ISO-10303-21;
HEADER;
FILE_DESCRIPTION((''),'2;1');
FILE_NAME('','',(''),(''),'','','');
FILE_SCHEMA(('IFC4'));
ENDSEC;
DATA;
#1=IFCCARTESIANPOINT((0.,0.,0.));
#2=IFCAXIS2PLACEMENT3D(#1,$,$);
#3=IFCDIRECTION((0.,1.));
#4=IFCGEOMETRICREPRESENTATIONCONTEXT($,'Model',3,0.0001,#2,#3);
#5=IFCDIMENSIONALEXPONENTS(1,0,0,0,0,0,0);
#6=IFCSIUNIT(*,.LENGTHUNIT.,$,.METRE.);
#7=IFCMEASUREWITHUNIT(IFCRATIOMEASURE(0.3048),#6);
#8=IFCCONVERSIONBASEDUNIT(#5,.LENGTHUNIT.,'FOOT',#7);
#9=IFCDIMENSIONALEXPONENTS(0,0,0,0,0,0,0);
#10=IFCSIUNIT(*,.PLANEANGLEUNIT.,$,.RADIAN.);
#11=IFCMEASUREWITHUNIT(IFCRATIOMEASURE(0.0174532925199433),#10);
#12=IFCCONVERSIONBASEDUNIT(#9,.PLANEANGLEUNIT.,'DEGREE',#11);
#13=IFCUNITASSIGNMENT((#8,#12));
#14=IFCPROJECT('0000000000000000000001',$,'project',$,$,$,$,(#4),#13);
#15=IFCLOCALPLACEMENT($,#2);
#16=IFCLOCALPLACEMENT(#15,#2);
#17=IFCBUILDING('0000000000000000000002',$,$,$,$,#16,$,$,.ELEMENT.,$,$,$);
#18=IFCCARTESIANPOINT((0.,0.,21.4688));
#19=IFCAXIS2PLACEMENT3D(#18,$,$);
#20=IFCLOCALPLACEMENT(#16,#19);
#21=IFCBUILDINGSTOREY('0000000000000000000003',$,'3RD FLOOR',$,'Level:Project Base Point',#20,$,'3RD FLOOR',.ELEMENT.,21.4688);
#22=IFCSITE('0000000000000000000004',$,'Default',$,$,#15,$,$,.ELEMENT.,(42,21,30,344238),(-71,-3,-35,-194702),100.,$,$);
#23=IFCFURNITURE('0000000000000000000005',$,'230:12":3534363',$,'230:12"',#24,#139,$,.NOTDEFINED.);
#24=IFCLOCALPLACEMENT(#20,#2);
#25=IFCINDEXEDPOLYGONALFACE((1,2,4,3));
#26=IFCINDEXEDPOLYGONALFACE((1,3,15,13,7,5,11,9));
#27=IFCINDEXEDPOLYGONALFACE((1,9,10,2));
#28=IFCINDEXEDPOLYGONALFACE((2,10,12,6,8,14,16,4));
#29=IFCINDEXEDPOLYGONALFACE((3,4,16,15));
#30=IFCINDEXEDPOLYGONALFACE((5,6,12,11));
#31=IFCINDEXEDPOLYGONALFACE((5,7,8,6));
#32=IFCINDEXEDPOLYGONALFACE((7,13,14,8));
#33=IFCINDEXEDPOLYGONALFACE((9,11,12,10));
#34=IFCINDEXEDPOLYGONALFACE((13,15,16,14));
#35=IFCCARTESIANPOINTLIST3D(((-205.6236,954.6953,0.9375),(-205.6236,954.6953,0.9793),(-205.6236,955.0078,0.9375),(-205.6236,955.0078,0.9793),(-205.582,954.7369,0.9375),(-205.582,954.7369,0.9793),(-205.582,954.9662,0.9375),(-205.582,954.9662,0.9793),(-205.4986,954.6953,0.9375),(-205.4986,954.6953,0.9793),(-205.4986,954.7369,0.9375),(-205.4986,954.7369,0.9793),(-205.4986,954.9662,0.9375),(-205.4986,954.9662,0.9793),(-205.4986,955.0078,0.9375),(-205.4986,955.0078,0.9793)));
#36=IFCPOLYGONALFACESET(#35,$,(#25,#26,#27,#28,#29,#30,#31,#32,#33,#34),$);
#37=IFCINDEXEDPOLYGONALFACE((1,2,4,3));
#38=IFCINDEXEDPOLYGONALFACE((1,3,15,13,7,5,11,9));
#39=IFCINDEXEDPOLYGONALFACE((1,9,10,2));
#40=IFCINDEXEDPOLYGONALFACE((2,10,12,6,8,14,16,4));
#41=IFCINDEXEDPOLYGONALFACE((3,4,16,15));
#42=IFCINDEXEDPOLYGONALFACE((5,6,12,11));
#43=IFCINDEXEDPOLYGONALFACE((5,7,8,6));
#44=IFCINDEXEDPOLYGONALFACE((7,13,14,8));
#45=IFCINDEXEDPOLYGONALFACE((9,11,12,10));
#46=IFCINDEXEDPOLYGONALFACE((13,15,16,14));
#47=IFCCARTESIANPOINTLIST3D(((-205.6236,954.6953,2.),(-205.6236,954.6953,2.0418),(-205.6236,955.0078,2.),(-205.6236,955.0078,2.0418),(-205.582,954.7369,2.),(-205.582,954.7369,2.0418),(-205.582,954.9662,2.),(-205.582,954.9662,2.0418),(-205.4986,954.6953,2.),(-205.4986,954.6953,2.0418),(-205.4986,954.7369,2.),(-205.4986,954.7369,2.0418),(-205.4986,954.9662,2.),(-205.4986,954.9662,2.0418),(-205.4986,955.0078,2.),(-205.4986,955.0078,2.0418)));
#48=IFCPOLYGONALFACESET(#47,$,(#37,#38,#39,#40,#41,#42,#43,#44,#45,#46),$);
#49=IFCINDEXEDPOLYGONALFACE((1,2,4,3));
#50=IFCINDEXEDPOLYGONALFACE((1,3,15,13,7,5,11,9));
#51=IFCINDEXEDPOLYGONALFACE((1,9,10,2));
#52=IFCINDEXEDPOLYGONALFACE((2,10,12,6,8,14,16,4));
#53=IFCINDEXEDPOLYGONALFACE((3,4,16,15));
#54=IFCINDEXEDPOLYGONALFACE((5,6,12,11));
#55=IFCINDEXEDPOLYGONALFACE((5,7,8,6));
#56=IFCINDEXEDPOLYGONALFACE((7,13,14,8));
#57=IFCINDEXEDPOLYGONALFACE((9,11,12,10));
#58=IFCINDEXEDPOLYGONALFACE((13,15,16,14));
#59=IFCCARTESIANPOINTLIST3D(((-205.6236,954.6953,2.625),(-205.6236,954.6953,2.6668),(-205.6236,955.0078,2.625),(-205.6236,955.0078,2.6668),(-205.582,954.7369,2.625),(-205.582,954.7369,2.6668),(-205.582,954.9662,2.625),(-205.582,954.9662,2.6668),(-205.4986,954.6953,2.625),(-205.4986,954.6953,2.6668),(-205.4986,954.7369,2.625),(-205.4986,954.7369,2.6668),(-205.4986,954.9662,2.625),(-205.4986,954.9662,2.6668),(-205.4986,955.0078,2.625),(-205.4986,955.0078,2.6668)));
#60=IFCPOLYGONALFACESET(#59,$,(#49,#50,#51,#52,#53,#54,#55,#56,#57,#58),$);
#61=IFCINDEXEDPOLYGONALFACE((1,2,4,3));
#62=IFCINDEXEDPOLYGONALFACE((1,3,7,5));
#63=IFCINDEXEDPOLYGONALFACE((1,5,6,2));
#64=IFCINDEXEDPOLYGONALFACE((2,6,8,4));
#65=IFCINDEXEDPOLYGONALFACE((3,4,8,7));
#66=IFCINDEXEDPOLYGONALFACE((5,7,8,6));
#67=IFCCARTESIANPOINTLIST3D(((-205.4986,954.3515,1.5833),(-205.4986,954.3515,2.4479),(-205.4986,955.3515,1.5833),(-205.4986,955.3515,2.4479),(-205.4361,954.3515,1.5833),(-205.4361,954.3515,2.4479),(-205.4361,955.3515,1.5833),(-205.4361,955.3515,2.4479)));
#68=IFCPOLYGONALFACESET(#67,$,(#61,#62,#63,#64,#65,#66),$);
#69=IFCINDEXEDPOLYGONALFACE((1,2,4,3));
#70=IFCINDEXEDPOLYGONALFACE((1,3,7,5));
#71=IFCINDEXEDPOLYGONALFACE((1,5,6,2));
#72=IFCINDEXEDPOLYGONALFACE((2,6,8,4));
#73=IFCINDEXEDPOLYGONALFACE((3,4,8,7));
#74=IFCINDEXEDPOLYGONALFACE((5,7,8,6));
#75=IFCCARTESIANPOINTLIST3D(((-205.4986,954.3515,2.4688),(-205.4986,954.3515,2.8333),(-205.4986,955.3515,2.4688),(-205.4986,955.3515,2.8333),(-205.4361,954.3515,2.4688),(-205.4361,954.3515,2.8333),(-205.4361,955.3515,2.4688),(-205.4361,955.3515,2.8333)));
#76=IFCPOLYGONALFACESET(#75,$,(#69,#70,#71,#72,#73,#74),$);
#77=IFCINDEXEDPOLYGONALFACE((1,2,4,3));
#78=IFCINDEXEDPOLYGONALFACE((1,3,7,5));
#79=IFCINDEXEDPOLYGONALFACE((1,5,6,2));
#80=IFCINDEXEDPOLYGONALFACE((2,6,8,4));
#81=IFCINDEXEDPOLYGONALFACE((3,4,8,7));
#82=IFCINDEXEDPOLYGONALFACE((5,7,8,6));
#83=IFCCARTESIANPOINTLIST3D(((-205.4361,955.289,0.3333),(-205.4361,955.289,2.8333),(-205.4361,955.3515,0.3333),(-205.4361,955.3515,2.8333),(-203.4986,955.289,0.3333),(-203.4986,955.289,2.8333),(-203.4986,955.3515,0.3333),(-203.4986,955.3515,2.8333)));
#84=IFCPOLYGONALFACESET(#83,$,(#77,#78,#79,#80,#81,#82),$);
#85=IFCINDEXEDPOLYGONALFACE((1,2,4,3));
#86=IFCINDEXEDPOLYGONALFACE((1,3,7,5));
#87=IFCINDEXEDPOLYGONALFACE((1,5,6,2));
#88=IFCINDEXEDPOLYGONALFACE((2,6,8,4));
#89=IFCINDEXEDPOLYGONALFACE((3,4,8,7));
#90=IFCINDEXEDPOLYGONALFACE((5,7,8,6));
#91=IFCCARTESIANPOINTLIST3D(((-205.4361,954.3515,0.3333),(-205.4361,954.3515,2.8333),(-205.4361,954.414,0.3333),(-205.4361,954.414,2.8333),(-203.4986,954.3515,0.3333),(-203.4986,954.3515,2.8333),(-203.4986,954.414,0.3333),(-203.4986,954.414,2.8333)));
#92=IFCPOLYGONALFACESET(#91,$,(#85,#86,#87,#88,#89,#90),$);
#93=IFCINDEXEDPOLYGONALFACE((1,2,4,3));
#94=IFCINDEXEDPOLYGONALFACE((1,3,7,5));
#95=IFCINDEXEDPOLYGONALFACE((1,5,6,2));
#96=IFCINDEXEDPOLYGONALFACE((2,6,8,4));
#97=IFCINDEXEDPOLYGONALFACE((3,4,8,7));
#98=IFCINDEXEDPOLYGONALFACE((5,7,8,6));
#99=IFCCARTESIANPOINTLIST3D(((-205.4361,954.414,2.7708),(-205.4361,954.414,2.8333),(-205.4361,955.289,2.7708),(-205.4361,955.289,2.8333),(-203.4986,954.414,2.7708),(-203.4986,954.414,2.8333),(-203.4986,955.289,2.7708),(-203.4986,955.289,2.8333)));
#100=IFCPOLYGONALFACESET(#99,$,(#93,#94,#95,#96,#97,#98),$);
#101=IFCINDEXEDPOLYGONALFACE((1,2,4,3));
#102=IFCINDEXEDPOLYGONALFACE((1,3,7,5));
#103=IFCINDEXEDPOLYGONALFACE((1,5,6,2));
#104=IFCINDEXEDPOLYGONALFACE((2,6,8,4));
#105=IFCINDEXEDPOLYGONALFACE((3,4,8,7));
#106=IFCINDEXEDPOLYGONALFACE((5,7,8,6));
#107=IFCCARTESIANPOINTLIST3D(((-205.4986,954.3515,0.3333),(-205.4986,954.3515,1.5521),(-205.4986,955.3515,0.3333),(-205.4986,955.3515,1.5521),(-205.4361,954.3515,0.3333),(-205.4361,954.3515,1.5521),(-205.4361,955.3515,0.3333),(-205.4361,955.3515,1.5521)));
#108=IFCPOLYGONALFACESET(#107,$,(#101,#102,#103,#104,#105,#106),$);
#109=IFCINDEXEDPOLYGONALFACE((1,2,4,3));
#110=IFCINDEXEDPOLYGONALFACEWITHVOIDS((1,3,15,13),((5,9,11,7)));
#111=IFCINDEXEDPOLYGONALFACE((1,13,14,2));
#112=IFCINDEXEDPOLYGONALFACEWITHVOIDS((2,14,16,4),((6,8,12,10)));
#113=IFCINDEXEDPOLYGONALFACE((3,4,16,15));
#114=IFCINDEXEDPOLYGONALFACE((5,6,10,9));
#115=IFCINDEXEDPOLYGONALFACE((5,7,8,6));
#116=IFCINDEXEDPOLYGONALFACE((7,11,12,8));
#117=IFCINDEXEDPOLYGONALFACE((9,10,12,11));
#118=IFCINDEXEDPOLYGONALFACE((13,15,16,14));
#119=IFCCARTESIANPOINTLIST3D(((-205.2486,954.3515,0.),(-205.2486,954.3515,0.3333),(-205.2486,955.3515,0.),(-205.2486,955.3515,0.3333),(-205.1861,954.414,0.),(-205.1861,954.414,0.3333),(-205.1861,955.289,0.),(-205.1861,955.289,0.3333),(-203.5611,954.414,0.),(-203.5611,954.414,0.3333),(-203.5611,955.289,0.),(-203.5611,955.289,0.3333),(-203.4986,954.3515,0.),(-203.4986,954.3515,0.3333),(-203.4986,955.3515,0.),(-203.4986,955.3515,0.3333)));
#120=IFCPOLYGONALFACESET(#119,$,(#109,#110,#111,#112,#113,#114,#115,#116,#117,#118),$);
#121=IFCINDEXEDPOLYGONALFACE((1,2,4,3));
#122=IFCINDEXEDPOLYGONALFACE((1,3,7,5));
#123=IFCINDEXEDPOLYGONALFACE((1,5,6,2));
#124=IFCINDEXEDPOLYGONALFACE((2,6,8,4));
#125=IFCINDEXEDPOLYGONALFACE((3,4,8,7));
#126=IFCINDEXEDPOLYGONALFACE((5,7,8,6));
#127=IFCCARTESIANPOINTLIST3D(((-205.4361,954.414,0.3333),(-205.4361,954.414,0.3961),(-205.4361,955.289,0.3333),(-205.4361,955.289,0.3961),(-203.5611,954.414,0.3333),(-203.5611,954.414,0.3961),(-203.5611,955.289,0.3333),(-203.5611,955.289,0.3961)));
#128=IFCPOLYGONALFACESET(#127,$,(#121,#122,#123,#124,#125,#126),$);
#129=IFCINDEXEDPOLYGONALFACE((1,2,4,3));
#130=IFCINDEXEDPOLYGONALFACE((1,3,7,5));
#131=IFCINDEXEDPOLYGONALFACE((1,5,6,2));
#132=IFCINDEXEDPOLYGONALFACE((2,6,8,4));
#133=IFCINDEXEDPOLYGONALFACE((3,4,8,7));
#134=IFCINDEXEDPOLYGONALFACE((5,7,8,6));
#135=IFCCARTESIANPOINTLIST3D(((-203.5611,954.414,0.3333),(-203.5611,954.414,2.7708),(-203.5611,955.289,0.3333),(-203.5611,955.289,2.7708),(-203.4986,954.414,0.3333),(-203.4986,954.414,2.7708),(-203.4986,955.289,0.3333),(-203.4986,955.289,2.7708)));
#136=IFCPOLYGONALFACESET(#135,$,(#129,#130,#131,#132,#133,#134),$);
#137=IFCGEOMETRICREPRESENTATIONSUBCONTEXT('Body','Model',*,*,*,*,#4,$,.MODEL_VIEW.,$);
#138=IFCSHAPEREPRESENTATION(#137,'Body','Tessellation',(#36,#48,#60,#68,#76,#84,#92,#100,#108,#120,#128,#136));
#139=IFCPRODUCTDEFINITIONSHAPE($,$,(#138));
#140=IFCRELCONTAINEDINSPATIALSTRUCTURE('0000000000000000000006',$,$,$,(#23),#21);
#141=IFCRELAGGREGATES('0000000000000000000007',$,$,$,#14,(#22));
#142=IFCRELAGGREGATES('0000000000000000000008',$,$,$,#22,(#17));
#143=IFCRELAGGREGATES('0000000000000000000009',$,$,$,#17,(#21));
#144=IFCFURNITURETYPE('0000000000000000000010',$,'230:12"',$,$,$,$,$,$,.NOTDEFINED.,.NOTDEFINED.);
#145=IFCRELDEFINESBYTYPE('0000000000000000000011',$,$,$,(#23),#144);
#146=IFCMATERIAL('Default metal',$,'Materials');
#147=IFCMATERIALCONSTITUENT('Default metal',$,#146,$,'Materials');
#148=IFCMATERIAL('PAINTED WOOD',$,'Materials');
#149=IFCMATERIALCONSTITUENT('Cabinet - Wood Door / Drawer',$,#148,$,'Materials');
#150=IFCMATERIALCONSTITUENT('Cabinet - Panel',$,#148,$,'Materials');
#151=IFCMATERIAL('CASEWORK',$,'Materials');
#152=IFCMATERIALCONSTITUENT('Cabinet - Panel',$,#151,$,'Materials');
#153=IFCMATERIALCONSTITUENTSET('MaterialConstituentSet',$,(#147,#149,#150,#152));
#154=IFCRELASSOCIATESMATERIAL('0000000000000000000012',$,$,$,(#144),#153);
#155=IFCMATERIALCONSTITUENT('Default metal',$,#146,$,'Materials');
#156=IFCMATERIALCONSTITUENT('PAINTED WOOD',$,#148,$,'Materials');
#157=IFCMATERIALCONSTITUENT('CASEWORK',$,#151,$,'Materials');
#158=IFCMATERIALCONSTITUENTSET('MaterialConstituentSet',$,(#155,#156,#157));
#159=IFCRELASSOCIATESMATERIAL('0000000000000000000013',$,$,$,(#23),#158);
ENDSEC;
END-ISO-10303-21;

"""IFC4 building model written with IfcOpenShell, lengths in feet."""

from ifc_helpers import new_model, entity, si_unit, converted_unit, direction, frame, frame_2d, origin, origin_2d_with_axis, place, context, subcontext, project, spatial, polyline, rectangle, outline, extrude, source, transform, mapped, material, constituent, constituent_set, type_object, type_shapes, element, save


model = new_model("IFC4")

# Units and contexts
model_context = context("Model", 3, precision=0.0001, world=origin(), true_north=direction((0.0, 1.0)))
body_context = subcontext(model_context, "Body", "Model", "MODEL_VIEW")
ifc_project = project(units=[converted_unit("LENGTHUNIT", "FOOT", entity("IfcRatioMeasure", 0.3048), si_unit("LENGTHUNIT", "METRE"), dimensions=[1, 0, 0, 0, 0, 0, 0]), converted_unit("PLANEANGLEUNIT", "DEGREE", entity("IfcRatioMeasure", 0.0174532925199433), si_unit("PLANEANGLEUNIT", "RADIAN"), dimensions=[0, 0, 0, 0, 0, 0, 0])], contexts=[model_context])

# Site, building, storey
site_placement = place(None, origin())
site = spatial("IfcSite", under=ifc_project, at=site_placement, Name="Default", CompositionType="ELEMENT", RefLatitude=(42, 21, 30, 344238), RefLongitude=(-71, -3, -35, -194702), RefElevation=100.0)
building_placement = place(site_placement, origin())
building = spatial("IfcBuilding", under=site, at=building_placement, CompositionType="ELEMENT")
storey_placement = place(building_placement, frame((0.0, 0.0, 21.4688)))
storey = spatial("IfcBuildingStorey", under=building, at=storey_placement, Name="3RD FLOOR", ObjectType="Level:Project Base Point", LongName="3RD FLOOR", CompositionType="ELEMENT", Elevation=21.4688)

# Furniture
ifc_material_1 = material(Name="CASEWORK", Category="Materials")
ifc_material_2 = material(Name="PAINTED WOOD", Category="Materials")
ifc_material_3 = material(Name="Default metal", Category="Materials")
ifc_constituent_1 = constituent(ifc_material_3, Name="Default metal", Category="Materials")
ifc_constituent_2 = constituent(ifc_material_2, Name="PAINTED WOOD", Category="Materials")
ifc_constituent_3 = constituent(ifc_material_1, Name="CASEWORK", Category="Materials")
ifc_constituent_set_1 = constituent_set(constituents=[ifc_constituent_1, ifc_constituent_2, ifc_constituent_3], Name="MaterialConstituentSet")
ifc_constituent_4 = constituent(ifc_material_3, Name="Default metal", Category="Materials")
ifc_constituent_5 = constituent(ifc_material_2, Name="Cabinet - Wood Door / Drawer", Category="Materials")
ifc_constituent_6 = constituent(ifc_material_2, Name="Cabinet - Panel", Category="Materials")
ifc_constituent_7 = constituent(ifc_material_1, Name="Cabinet - Panel", Category="Materials")
ifc_constituent_set_2 = constituent_set(constituents=[ifc_constituent_4, ifc_constituent_5, ifc_constituent_6, ifc_constituent_7], Name="MaterialConstituentSet")
furniture_type_1 = type_object("IfcFurnitureType", Name="230:12\"", AssemblyPlace="NOTDEFINED", PredefinedType="NOTDEFINED", material=ifc_constituent_set_2)
shared_shape_1 = source(origin(), body_context, "Body", "SweptSolid", [
    extrude(outline(polyline([(-0.0521, -0.1562), (0.0729, -0.1562), (0.0729, 0.1562), (-0.0521, 0.1562), (-0.0521, 0.1146), (0.0313, 0.1146), (0.0313, -0.1146), (-0.0521, -0.1146), (-0.0521, -0.1562)])), frame((0.0615, -2.0521, 0.9375), z_axis=(0.0, 0.0, 1.0), x_axis=(0.0, -1.0, 0.0)), (0.0, 0.0, 1.0), 0.0418),
    extrude(outline(polyline([(-0.0521, -0.1562), (0.0729, -0.1562), (0.0729, 0.1562), (-0.0521, 0.1562), (-0.0521, 0.1146), (0.0313, 0.1146), (0.0313, -0.1146), (-0.0521, -0.1146), (-0.0521, -0.1562)])), frame((0.0615, -2.0521, 2.0), z_axis=(0.0, 0.0, 1.0), x_axis=(0.0, -1.0, 0.0)), (0.0, 0.0, 1.0), 0.0418),
    extrude(outline(polyline([(-0.0521, -0.1562), (0.0729, -0.1562), (0.0729, 0.1562), (-0.0521, 0.1562), (-0.0521, 0.1146), (0.0313, 0.1146), (0.0313, -0.1146), (-0.0521, -0.1146), (-0.0521, -0.1562)])), frame((0.0615, -2.0521, 2.625), z_axis=(0.0, 0.0, 1.0), x_axis=(0.0, -1.0, 0.0)), (0.0, 0.0, 1.0), 0.0418),
    extrude(rectangle(XDim=0.0625, YDim=1.0, at=origin_2d_with_axis()), frame((0.0615, -1.9688, 1.5833), z_axis=(0.0, 0.0, 1.0), x_axis=(0.0, 1.0, 0.0)), (0.0, 0.0, 1.0), 0.8646),
    extrude(rectangle(XDim=0.0625, YDim=1.0, at=origin_2d_with_axis()), frame((0.0615, -1.9688, 2.4688), z_axis=(0.0, 0.0, 1.0), x_axis=(0.0, 1.0, 0.0)), (0.0, 0.0, 1.0), 0.3646),
    extrude(rectangle(XDim=0.0625, YDim=1.9375, at=frame_2d((0.0, 0.0), x_axis=(1.0, 0.0))), frame((-0.4073, -0.9687, 0.3333)), (0.0, 0.0, 1.0), 2.5),
    extrude(rectangle(XDim=0.0625, YDim=1.9375, at=frame_2d((0.0, 0.0), x_axis=(1.0, 0.0))), frame((0.5302, -0.9687, 0.3333)), (0.0, 0.0, 1.0), 2.5),
    extrude(rectangle(XDim=0.875, YDim=1.9375, at=origin_2d_with_axis()), frame((0.0615, -0.9687, 2.7708), z_axis=(0.0, 0.0, 1.0), x_axis=(-1.0, 0.0, 0.0)), (0.0, 0.0, 1.0), 0.0625),
    extrude(rectangle(XDim=0.0625, YDim=1.0, at=origin_2d_with_axis()), frame((0.0615, -1.9688, 0.3333), z_axis=(0.0, 0.0, 1.0), x_axis=(0.0, 1.0, 0.0)), (0.0, 0.0, 1.0), 1.2187),
    extrude(outline(polyline([(-0.5, -0.875), (0.5, -0.875), (0.5, 0.875), (-0.5, 0.875), (-0.5, -0.875)]), holes=[polyline([(-0.4375, -0.8125), (-0.4375, 0.8125), (0.4375, 0.8125), (0.4375, -0.8125), (-0.4375, -0.8125)])]), frame((0.0615, -0.875, 0.0)), (0.0, 0.0, 1.0), 0.3333),
    extrude(rectangle(XDim=0.875, YDim=1.875, at=frame_2d((0.0, 0.0), x_axis=(1.0, 0.0))), frame((0.0615, -1.0, 0.3333), z_axis=(0.0, 0.0, 1.0), x_axis=(-1.0, 0.0, 0.0)), (0.0, 0.0, 1.0), 0.0627),
    extrude(rectangle(XDim=0.0625, YDim=0.875, at=origin_2d_with_axis()), frame((0.0615, -0.0312, 0.3333), z_axis=(0.0, 0.0, 1.0), x_axis=(0.0, 1.0, 0.0)), (0.0, 0.0, 1.0), 2.4375),
])
type_shapes(furniture_type_1, [shared_shape_1])
furniture_1_placement = place(storey_placement, frame((-203.4986, 954.913, 0.0), z_axis=(0.0, 0.0, 1.0), x_axis=(0.0, -1.0, 0.0)))
element("IfcFurniture", 1, at=furniture_1_placement, inside=storey, type_object=furniture_type_1, material=ifc_constituent_set_1, Name="230:12\":3534363", ObjectType="230:12\"", PredefinedType="NOTDEFINED", context=body_context, shape_type="MappedRepresentation", body=[
    mapped(shared_shape_1, transform((0.0, 0.0, 0.0), scale=1.0)),
])

save(model, "model.ifc")
